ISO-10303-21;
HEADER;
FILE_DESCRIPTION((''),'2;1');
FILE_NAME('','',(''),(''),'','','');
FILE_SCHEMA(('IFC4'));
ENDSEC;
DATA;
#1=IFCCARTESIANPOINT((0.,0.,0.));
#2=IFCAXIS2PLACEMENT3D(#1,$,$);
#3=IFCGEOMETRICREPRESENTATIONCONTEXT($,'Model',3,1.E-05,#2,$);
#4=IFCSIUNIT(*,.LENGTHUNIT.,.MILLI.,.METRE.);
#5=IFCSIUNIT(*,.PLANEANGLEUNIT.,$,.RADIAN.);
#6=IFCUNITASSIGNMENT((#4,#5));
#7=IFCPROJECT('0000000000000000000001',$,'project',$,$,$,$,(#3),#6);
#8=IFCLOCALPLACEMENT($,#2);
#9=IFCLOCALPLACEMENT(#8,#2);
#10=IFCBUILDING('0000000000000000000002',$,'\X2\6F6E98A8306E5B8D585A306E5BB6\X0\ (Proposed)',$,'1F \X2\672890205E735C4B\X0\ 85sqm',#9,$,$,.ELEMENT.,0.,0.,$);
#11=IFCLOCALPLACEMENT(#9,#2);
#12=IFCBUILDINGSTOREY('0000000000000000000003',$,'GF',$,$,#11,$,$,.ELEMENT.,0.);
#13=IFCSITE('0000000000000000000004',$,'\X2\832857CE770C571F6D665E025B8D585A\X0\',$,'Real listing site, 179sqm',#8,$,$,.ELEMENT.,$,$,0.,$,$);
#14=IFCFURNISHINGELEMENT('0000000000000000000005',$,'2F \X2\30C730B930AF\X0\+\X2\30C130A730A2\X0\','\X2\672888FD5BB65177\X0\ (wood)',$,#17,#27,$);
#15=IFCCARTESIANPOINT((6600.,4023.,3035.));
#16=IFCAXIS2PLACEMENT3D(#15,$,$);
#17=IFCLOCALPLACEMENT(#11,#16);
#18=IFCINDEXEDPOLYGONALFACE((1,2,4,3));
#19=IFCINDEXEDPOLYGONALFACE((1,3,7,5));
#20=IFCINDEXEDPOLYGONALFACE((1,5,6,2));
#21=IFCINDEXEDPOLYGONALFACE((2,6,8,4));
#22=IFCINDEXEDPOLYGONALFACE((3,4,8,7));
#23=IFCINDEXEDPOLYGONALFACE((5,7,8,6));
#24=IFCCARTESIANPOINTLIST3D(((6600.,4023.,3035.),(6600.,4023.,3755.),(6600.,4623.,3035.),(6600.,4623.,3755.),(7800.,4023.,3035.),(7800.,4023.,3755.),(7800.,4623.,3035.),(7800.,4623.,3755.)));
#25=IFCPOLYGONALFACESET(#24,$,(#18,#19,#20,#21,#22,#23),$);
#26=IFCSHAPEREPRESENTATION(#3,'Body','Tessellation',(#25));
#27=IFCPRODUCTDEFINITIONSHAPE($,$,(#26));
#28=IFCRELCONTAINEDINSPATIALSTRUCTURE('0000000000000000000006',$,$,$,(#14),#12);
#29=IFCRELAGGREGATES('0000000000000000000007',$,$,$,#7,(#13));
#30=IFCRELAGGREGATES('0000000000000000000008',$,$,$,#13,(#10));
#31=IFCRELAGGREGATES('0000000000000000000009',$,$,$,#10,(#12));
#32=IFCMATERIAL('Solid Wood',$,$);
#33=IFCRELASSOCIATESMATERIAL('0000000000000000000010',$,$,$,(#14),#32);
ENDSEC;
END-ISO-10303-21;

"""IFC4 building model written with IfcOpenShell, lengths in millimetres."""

from ifc_helpers import new_model, si_unit, frame, frame_2d, origin, place, context, project, spatial, rectangle, extrude, material, element, save


model = new_model("IFC4")

# Units and contexts
model_context = context("Model", 3, precision=1e-05, world=origin())
ifc_project = project(units=[si_unit("LENGTHUNIT", "METRE", prefix="MILLI"), si_unit("PLANEANGLEUNIT", "RADIAN")], contexts=[model_context])

# Site, building, storey
site_placement = place(None, origin())
site = spatial("IfcSite", under=ifc_project, at=site_placement, Name="茨城県土浦市宍塚", ObjectType="Real listing site, 179sqm", CompositionType="ELEMENT", RefElevation=0.0)
building_placement = place(site_placement, origin())
building = spatial("IfcBuilding", under=site, at=building_placement, Name="潮風の宍塚の家 (Proposed)", ObjectType="1F 木造平屋 85sqm", CompositionType="ELEMENT", ElevationOfRefHeight=0.0, ElevationOfTerrain=0.0)
storey_placement = place(building_placement, origin())
storey = spatial("IfcBuildingStorey", under=building, at=storey_placement, Name="GF", CompositionType="ELEMENT", Elevation=0.0)

# Shared definitions
ifc_material_1 = material(Name="Solid Wood")

# Furnishing element
furnishing_1_placement = place(storey_placement, frame((6600.0, 4023.0, 3035.0)))
element("IfcFurnishingElement", 1, at=furnishing_1_placement, inside=storey, material=ifc_material_1, Name="2F デスク+チェア", Description="木製家具 (wood)", context=model_context, shape_type="SweptSolid", body=[
    extrude(rectangle(XDim=1200.0, YDim=600.0, at=frame_2d((600.0, 300.0))), frame((6600.0, 4023.0, 3035.0)), (0.0, 0.0, 1.0), 720.0),
])

save(model, "model.ifc")
